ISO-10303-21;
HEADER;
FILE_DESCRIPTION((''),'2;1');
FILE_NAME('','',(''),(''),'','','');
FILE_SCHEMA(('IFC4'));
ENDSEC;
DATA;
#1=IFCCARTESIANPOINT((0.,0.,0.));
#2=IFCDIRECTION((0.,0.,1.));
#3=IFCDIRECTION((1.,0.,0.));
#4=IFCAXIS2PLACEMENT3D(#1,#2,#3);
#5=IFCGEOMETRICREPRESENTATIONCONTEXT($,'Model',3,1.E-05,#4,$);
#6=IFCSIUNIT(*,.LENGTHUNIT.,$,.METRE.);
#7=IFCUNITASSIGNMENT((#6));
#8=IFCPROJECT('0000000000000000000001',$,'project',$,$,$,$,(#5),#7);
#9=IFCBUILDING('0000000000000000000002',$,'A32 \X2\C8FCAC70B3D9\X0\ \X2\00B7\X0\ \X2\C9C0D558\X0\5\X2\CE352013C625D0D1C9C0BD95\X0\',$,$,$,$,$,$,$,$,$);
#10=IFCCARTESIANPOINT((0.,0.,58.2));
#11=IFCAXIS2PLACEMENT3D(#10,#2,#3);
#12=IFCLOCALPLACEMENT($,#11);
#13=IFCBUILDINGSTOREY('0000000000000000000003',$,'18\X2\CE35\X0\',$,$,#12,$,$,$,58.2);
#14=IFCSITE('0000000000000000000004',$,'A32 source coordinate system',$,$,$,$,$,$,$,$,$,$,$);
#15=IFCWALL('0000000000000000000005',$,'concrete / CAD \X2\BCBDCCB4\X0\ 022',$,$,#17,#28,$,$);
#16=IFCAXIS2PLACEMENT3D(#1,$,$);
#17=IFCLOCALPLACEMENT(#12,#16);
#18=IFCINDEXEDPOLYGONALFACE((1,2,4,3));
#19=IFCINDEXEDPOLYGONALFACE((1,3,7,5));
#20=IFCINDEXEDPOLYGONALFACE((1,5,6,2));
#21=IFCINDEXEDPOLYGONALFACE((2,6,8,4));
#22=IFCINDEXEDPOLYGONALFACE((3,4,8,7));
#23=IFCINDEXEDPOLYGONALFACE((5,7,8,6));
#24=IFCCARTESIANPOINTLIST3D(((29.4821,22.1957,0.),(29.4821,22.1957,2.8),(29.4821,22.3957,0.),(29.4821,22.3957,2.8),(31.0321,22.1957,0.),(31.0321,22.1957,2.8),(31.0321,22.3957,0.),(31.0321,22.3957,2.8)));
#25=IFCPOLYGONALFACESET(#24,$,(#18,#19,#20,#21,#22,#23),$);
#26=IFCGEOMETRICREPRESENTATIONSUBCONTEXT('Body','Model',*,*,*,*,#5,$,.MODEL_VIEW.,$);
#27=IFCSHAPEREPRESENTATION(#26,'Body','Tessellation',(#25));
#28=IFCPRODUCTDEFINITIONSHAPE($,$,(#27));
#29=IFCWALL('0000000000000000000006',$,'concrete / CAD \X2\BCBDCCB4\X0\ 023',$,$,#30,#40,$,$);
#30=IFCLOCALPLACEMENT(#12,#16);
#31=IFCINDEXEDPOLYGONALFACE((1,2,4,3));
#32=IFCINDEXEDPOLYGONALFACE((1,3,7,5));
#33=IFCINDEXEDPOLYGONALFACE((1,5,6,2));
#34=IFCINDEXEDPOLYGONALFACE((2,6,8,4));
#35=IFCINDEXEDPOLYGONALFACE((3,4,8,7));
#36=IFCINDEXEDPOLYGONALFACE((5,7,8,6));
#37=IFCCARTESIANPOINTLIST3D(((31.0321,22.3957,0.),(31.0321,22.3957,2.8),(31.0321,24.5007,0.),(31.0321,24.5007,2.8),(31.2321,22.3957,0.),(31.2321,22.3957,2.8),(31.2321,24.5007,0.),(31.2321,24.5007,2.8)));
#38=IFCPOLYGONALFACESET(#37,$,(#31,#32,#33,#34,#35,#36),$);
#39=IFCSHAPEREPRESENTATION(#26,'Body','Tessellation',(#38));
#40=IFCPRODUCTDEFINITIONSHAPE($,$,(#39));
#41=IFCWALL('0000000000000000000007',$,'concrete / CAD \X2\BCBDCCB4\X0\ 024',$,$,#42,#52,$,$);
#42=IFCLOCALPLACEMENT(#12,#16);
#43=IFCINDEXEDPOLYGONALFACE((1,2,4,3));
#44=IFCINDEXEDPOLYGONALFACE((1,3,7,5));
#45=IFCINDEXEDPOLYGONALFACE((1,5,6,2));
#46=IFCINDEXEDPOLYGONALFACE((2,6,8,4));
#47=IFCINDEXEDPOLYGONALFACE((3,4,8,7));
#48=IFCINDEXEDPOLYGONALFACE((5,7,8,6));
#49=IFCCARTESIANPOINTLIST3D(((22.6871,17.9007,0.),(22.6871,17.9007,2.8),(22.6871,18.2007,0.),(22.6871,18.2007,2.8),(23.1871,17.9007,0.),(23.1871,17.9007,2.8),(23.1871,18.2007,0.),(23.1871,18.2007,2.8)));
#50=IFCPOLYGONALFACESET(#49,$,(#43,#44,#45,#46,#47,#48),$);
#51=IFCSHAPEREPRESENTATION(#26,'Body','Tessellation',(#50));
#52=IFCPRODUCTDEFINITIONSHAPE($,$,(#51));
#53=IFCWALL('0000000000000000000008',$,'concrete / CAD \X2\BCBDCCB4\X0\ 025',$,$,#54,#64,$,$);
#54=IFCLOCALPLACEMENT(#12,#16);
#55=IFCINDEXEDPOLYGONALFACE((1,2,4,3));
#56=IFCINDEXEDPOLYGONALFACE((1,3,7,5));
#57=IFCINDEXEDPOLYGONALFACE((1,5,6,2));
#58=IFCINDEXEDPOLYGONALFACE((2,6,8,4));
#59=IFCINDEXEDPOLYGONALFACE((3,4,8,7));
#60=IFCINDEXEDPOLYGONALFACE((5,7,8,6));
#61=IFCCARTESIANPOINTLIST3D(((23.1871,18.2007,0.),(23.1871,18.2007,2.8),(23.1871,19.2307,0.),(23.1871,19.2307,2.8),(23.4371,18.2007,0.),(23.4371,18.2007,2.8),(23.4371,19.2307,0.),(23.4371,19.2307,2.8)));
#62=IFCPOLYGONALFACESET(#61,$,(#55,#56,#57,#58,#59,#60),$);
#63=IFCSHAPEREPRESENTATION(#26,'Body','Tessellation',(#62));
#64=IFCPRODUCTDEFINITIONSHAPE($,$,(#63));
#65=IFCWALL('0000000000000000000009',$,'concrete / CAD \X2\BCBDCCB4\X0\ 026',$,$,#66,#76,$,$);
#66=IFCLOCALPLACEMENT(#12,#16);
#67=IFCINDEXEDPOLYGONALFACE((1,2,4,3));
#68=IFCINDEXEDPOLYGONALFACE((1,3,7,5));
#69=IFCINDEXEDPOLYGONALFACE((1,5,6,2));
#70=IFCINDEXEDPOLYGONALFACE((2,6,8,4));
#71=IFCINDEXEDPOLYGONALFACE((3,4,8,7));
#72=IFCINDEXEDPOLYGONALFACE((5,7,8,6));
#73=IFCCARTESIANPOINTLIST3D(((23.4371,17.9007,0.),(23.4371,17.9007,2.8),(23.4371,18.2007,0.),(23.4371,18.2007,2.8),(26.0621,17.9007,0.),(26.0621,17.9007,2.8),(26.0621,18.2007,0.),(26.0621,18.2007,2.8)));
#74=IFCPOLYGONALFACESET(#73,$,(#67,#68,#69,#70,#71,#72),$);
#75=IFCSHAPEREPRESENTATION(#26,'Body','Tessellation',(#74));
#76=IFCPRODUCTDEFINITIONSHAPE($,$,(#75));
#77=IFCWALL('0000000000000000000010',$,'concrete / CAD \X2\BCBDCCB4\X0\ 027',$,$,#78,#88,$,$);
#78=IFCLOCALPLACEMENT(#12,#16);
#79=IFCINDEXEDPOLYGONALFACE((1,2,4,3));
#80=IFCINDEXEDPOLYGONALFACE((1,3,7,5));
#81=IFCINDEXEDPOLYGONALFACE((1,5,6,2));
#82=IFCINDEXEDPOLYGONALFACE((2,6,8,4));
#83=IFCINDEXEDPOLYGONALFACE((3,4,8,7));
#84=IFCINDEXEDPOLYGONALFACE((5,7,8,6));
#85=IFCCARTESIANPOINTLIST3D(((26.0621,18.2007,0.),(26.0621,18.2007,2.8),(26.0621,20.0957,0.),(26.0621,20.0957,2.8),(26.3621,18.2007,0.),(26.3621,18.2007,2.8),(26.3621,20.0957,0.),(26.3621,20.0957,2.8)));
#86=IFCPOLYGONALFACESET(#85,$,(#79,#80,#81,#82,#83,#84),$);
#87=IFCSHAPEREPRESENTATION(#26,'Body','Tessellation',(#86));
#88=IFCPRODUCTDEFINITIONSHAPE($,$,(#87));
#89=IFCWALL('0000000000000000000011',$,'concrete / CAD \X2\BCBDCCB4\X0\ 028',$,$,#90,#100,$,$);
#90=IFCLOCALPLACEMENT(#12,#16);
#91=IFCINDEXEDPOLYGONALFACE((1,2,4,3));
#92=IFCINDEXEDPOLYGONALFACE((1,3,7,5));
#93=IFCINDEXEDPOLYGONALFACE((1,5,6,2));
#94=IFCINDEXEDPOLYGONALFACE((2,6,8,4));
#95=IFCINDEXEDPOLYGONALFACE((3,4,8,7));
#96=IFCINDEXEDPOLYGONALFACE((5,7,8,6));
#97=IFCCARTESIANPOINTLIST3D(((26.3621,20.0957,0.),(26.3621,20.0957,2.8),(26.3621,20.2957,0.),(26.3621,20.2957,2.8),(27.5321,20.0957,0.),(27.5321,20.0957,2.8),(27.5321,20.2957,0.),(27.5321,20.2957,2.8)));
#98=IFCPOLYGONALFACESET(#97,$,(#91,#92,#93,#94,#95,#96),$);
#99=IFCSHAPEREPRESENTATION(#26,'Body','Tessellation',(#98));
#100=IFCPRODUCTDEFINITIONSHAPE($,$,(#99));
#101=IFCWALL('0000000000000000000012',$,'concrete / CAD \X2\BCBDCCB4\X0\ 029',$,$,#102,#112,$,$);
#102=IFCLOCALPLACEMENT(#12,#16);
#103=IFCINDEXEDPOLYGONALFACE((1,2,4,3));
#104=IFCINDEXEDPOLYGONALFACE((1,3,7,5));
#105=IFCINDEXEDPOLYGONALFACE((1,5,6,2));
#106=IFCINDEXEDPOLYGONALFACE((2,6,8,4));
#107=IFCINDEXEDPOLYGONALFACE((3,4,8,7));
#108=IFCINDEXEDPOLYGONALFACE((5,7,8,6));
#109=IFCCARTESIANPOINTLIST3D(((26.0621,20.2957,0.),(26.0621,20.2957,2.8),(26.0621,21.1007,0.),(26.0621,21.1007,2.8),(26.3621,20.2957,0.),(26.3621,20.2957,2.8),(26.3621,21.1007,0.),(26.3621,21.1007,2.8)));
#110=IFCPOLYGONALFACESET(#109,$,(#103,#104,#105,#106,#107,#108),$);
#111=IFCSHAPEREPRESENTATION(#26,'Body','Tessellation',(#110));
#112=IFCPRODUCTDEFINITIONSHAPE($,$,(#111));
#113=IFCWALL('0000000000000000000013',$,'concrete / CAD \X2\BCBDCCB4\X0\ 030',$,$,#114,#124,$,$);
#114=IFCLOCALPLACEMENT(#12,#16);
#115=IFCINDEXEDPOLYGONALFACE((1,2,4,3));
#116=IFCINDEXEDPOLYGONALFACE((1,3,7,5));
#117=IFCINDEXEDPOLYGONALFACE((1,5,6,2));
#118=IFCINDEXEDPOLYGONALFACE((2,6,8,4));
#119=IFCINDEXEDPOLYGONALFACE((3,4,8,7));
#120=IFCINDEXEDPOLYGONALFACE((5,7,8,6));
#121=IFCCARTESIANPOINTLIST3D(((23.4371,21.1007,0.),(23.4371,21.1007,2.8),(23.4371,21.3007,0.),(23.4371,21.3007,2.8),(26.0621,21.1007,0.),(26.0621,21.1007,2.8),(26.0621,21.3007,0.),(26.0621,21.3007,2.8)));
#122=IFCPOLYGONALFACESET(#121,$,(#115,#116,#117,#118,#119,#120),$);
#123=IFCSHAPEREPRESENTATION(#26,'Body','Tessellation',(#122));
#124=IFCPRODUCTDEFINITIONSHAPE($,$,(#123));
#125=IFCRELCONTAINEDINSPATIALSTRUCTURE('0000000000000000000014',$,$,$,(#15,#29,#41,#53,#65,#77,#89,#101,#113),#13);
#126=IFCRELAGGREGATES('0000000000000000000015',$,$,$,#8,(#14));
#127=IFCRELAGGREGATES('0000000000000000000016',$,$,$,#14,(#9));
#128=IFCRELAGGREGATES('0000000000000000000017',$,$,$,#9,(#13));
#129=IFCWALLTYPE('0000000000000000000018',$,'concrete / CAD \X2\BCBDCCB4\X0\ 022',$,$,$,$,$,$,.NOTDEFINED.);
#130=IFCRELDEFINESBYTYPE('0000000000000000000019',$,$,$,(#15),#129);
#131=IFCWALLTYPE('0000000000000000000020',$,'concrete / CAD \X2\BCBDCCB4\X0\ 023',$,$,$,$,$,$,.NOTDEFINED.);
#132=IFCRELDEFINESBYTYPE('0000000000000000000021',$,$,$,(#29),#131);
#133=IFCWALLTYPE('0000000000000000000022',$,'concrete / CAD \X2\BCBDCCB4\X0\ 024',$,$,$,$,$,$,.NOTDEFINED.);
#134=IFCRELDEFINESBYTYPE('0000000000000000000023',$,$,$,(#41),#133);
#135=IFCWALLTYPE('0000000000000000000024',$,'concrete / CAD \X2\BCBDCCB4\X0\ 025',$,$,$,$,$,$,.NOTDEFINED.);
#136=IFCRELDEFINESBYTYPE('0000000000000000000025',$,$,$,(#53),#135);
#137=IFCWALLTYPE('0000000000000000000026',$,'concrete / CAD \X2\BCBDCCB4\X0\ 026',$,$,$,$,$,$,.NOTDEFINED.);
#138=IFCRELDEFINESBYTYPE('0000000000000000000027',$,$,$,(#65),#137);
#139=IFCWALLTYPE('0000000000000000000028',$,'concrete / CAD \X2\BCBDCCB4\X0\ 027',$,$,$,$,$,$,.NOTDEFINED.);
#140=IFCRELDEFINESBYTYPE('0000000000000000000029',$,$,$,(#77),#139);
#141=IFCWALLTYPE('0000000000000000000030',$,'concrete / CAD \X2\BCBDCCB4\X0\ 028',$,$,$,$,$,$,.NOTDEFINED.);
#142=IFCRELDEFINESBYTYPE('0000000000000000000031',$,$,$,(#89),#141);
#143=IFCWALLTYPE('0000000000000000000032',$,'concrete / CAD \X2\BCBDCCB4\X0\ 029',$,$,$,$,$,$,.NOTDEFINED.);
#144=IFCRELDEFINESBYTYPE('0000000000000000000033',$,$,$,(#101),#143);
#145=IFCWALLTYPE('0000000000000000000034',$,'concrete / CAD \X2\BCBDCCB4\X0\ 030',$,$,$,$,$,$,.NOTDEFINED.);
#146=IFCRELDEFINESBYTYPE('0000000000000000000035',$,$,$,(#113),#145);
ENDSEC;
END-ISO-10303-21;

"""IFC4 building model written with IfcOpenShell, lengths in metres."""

from ifc_helpers import new_model, si_unit, frame, origin, origin_with_axes, place, context, subcontext, project, spatial, polyline, outline, extrude, source, transform, mapped, type_object, type_shapes, element, save


model = new_model("IFC4")

# Units and contexts
model_context = context("Model", 3, precision=1e-05, world=origin_with_axes())
body_context = subcontext(model_context, "Body", "Model", "MODEL_VIEW")
ifc_project = project(units=[si_unit("LENGTHUNIT", "METRE")], contexts=[model_context])

# Site, building, storey
site = spatial("IfcSite", under=ifc_project, Name="A32 source coordinate system")
building = spatial("IfcBuilding", under=site, Name="A32 주거동 · 지하5층–옥탑지붕")
storey_placement = place(None, frame((0.0, 0.0, 58.2), z_axis=(0.0, 0.0, 1.0), x_axis=(1.0, 0.0, 0.0)))
storey = spatial("IfcBuildingStorey", under=building, at=storey_placement, Name="18층", Elevation=58.2)

# Walls
wall_type_1 = type_object("IfcWallType", Name="concrete / CAD 벽체 022", PredefinedType="NOTDEFINED")
shared_shape_1 = source(origin(), body_context, "Body", "SweptSolid", [
    extrude(outline(polyline([(31.0321, 22.1957), (29.4821, 22.1957), (29.4821, 22.3957), (31.0321, 22.3957), (31.0321, 22.1957)])), origin(), (0.0, 0.0, 1.0), 2.8),
])
type_shapes(wall_type_1, [shared_shape_1])
wall_1_placement = place(storey_placement, origin_with_axes())
element("IfcWall", 1, at=wall_1_placement, inside=storey, type_object=wall_type_1, Name="concrete / CAD 벽체 022", context=body_context, shape_type="MappedRepresentation", body=[
    mapped(shared_shape_1, transform((0.0, 0.0, 0.0), scale=1.0)),
])
wall_type_2 = type_object("IfcWallType", Name="concrete / CAD 벽체 023", PredefinedType="NOTDEFINED")
shared_shape_2 = source(origin(), body_context, "Body", "SweptSolid", [
    extrude(outline(polyline([(31.2321, 24.5007), (31.2321, 22.3957), (31.0321, 22.3957), (31.0321, 24.5007), (31.2321, 24.5007)])), origin(), (0.0, 0.0, 1.0), 2.8),
])
type_shapes(wall_type_2, [shared_shape_2])
wall_2_placement = place(storey_placement, origin_with_axes())
element("IfcWall", 2, at=wall_2_placement, inside=storey, type_object=wall_type_2, Name="concrete / CAD 벽체 023", context=body_context, shape_type="MappedRepresentation", body=[
    mapped(shared_shape_2, transform((0.0, 0.0, 0.0), scale=1.0)),
])
wall_type_3 = type_object("IfcWallType", Name="concrete / CAD 벽체 024", PredefinedType="NOTDEFINED")
shared_shape_3 = source(origin(), body_context, "Body", "SweptSolid", [
    extrude(outline(polyline([(23.1871, 17.9007), (22.6871, 17.9007), (22.6871, 18.2007), (23.1871, 18.2007), (23.1871, 17.9007)])), origin(), (0.0, 0.0, 1.0), 2.8),
])
type_shapes(wall_type_3, [shared_shape_3])
wall_3_placement = place(storey_placement, origin_with_axes())
element("IfcWall", 3, at=wall_3_placement, inside=storey, type_object=wall_type_3, Name="concrete / CAD 벽체 024", context=body_context, shape_type="MappedRepresentation", body=[
    mapped(shared_shape_3, transform((0.0, 0.0, 0.0), scale=1.0)),
])
wall_type_4 = type_object("IfcWallType", Name="concrete / CAD 벽체 025", PredefinedType="NOTDEFINED")
shared_shape_4 = source(origin(), body_context, "Body", "SweptSolid", [
    extrude(outline(polyline([(23.4371, 19.2307), (23.4371, 18.2007), (23.1871, 18.2007), (23.1871, 19.2307), (23.4371, 19.2307)])), origin(), (0.0, 0.0, 1.0), 2.8),
])
type_shapes(wall_type_4, [shared_shape_4])
wall_4_placement = place(storey_placement, origin_with_axes())
element("IfcWall", 4, at=wall_4_placement, inside=storey, type_object=wall_type_4, Name="concrete / CAD 벽체 025", context=body_context, shape_type="MappedRepresentation", body=[
    mapped(shared_shape_4, transform((0.0, 0.0, 0.0), scale=1.0)),
])
wall_type_5 = type_object("IfcWallType", Name="concrete / CAD 벽체 026", PredefinedType="NOTDEFINED")
shared_shape_5 = source(origin(), body_context, "Body", "SweptSolid", [
    extrude(outline(polyline([(26.0621, 17.9007), (23.4371, 17.9007), (23.4371, 18.2007), (26.0621, 18.2007), (26.0621, 17.9007)])), origin(), (0.0, 0.0, 1.0), 2.8),
])
type_shapes(wall_type_5, [shared_shape_5])
wall_5_placement = place(storey_placement, origin_with_axes())
element("IfcWall", 5, at=wall_5_placement, inside=storey, type_object=wall_type_5, Name="concrete / CAD 벽체 026", context=body_context, shape_type="MappedRepresentation", body=[
    mapped(shared_shape_5, transform((0.0, 0.0, 0.0), scale=1.0)),
])
wall_type_6 = type_object("IfcWallType", Name="concrete / CAD 벽체 027", PredefinedType="NOTDEFINED")
shared_shape_6 = source(origin(), body_context, "Body", "SweptSolid", [
    extrude(outline(polyline([(26.3621, 20.0957), (26.3621, 18.2007), (26.0621, 18.2007), (26.0621, 20.0957), (26.3621, 20.0957)])), origin(), (0.0, 0.0, 1.0), 2.8),
])
type_shapes(wall_type_6, [shared_shape_6])
wall_6_placement = place(storey_placement, origin_with_axes())
element("IfcWall", 6, at=wall_6_placement, inside=storey, type_object=wall_type_6, Name="concrete / CAD 벽체 027", context=body_context, shape_type="MappedRepresentation", body=[
    mapped(shared_shape_6, transform((0.0, 0.0, 0.0), scale=1.0)),
])
wall_type_7 = type_object("IfcWallType", Name="concrete / CAD 벽체 028", PredefinedType="NOTDEFINED")
shared_shape_7 = source(origin(), body_context, "Body", "SweptSolid", [
    extrude(outline(polyline([(27.5321, 20.0957), (26.3621, 20.0957), (26.3621, 20.2957), (27.5321, 20.2957), (27.5321, 20.0957)])), origin(), (0.0, 0.0, 1.0), 2.8),
])
type_shapes(wall_type_7, [shared_shape_7])
wall_7_placement = place(storey_placement, origin_with_axes())
element("IfcWall", 7, at=wall_7_placement, inside=storey, type_object=wall_type_7, Name="concrete / CAD 벽체 028", context=body_context, shape_type="MappedRepresentation", body=[
    mapped(shared_shape_7, transform((0.0, 0.0, 0.0), scale=1.0)),
])
wall_type_8 = type_object("IfcWallType", Name="concrete / CAD 벽체 029", PredefinedType="NOTDEFINED")
shared_shape_8 = source(origin(), body_context, "Body", "SweptSolid", [
    extrude(outline(polyline([(26.3621, 21.1007), (26.3621, 20.2957), (26.0621, 20.2957), (26.0621, 21.1007), (26.3621, 21.1007)])), origin(), (0.0, 0.0, 1.0), 2.8),
])
type_shapes(wall_type_8, [shared_shape_8])
wall_8_placement = place(storey_placement, origin_with_axes())
element("IfcWall", 8, at=wall_8_placement, inside=storey, type_object=wall_type_8, Name="concrete / CAD 벽체 029", context=body_context, shape_type="MappedRepresentation", body=[
    mapped(shared_shape_8, transform((0.0, 0.0, 0.0), scale=1.0)),
])
wall_type_9 = type_object("IfcWallType", Name="concrete / CAD 벽체 030", PredefinedType="NOTDEFINED")
shared_shape_9 = source(origin(), body_context, "Body", "SweptSolid", [
    extrude(outline(polyline([(23.4371, 21.3007), (26.0621, 21.3007), (26.0621, 21.1007), (23.4371, 21.1007), (23.4371, 21.3007)])), origin(), (0.0, 0.0, 1.0), 2.8),
])
type_shapes(wall_type_9, [shared_shape_9])
wall_9_placement = place(storey_placement, origin_with_axes())
element("IfcWall", 9, at=wall_9_placement, inside=storey, type_object=wall_type_9, Name="concrete / CAD 벽체 030", context=body_context, shape_type="MappedRepresentation", body=[
    mapped(shared_shape_9, transform((0.0, 0.0, 0.0), scale=1.0)),
])

save(model, "model.ifc")
